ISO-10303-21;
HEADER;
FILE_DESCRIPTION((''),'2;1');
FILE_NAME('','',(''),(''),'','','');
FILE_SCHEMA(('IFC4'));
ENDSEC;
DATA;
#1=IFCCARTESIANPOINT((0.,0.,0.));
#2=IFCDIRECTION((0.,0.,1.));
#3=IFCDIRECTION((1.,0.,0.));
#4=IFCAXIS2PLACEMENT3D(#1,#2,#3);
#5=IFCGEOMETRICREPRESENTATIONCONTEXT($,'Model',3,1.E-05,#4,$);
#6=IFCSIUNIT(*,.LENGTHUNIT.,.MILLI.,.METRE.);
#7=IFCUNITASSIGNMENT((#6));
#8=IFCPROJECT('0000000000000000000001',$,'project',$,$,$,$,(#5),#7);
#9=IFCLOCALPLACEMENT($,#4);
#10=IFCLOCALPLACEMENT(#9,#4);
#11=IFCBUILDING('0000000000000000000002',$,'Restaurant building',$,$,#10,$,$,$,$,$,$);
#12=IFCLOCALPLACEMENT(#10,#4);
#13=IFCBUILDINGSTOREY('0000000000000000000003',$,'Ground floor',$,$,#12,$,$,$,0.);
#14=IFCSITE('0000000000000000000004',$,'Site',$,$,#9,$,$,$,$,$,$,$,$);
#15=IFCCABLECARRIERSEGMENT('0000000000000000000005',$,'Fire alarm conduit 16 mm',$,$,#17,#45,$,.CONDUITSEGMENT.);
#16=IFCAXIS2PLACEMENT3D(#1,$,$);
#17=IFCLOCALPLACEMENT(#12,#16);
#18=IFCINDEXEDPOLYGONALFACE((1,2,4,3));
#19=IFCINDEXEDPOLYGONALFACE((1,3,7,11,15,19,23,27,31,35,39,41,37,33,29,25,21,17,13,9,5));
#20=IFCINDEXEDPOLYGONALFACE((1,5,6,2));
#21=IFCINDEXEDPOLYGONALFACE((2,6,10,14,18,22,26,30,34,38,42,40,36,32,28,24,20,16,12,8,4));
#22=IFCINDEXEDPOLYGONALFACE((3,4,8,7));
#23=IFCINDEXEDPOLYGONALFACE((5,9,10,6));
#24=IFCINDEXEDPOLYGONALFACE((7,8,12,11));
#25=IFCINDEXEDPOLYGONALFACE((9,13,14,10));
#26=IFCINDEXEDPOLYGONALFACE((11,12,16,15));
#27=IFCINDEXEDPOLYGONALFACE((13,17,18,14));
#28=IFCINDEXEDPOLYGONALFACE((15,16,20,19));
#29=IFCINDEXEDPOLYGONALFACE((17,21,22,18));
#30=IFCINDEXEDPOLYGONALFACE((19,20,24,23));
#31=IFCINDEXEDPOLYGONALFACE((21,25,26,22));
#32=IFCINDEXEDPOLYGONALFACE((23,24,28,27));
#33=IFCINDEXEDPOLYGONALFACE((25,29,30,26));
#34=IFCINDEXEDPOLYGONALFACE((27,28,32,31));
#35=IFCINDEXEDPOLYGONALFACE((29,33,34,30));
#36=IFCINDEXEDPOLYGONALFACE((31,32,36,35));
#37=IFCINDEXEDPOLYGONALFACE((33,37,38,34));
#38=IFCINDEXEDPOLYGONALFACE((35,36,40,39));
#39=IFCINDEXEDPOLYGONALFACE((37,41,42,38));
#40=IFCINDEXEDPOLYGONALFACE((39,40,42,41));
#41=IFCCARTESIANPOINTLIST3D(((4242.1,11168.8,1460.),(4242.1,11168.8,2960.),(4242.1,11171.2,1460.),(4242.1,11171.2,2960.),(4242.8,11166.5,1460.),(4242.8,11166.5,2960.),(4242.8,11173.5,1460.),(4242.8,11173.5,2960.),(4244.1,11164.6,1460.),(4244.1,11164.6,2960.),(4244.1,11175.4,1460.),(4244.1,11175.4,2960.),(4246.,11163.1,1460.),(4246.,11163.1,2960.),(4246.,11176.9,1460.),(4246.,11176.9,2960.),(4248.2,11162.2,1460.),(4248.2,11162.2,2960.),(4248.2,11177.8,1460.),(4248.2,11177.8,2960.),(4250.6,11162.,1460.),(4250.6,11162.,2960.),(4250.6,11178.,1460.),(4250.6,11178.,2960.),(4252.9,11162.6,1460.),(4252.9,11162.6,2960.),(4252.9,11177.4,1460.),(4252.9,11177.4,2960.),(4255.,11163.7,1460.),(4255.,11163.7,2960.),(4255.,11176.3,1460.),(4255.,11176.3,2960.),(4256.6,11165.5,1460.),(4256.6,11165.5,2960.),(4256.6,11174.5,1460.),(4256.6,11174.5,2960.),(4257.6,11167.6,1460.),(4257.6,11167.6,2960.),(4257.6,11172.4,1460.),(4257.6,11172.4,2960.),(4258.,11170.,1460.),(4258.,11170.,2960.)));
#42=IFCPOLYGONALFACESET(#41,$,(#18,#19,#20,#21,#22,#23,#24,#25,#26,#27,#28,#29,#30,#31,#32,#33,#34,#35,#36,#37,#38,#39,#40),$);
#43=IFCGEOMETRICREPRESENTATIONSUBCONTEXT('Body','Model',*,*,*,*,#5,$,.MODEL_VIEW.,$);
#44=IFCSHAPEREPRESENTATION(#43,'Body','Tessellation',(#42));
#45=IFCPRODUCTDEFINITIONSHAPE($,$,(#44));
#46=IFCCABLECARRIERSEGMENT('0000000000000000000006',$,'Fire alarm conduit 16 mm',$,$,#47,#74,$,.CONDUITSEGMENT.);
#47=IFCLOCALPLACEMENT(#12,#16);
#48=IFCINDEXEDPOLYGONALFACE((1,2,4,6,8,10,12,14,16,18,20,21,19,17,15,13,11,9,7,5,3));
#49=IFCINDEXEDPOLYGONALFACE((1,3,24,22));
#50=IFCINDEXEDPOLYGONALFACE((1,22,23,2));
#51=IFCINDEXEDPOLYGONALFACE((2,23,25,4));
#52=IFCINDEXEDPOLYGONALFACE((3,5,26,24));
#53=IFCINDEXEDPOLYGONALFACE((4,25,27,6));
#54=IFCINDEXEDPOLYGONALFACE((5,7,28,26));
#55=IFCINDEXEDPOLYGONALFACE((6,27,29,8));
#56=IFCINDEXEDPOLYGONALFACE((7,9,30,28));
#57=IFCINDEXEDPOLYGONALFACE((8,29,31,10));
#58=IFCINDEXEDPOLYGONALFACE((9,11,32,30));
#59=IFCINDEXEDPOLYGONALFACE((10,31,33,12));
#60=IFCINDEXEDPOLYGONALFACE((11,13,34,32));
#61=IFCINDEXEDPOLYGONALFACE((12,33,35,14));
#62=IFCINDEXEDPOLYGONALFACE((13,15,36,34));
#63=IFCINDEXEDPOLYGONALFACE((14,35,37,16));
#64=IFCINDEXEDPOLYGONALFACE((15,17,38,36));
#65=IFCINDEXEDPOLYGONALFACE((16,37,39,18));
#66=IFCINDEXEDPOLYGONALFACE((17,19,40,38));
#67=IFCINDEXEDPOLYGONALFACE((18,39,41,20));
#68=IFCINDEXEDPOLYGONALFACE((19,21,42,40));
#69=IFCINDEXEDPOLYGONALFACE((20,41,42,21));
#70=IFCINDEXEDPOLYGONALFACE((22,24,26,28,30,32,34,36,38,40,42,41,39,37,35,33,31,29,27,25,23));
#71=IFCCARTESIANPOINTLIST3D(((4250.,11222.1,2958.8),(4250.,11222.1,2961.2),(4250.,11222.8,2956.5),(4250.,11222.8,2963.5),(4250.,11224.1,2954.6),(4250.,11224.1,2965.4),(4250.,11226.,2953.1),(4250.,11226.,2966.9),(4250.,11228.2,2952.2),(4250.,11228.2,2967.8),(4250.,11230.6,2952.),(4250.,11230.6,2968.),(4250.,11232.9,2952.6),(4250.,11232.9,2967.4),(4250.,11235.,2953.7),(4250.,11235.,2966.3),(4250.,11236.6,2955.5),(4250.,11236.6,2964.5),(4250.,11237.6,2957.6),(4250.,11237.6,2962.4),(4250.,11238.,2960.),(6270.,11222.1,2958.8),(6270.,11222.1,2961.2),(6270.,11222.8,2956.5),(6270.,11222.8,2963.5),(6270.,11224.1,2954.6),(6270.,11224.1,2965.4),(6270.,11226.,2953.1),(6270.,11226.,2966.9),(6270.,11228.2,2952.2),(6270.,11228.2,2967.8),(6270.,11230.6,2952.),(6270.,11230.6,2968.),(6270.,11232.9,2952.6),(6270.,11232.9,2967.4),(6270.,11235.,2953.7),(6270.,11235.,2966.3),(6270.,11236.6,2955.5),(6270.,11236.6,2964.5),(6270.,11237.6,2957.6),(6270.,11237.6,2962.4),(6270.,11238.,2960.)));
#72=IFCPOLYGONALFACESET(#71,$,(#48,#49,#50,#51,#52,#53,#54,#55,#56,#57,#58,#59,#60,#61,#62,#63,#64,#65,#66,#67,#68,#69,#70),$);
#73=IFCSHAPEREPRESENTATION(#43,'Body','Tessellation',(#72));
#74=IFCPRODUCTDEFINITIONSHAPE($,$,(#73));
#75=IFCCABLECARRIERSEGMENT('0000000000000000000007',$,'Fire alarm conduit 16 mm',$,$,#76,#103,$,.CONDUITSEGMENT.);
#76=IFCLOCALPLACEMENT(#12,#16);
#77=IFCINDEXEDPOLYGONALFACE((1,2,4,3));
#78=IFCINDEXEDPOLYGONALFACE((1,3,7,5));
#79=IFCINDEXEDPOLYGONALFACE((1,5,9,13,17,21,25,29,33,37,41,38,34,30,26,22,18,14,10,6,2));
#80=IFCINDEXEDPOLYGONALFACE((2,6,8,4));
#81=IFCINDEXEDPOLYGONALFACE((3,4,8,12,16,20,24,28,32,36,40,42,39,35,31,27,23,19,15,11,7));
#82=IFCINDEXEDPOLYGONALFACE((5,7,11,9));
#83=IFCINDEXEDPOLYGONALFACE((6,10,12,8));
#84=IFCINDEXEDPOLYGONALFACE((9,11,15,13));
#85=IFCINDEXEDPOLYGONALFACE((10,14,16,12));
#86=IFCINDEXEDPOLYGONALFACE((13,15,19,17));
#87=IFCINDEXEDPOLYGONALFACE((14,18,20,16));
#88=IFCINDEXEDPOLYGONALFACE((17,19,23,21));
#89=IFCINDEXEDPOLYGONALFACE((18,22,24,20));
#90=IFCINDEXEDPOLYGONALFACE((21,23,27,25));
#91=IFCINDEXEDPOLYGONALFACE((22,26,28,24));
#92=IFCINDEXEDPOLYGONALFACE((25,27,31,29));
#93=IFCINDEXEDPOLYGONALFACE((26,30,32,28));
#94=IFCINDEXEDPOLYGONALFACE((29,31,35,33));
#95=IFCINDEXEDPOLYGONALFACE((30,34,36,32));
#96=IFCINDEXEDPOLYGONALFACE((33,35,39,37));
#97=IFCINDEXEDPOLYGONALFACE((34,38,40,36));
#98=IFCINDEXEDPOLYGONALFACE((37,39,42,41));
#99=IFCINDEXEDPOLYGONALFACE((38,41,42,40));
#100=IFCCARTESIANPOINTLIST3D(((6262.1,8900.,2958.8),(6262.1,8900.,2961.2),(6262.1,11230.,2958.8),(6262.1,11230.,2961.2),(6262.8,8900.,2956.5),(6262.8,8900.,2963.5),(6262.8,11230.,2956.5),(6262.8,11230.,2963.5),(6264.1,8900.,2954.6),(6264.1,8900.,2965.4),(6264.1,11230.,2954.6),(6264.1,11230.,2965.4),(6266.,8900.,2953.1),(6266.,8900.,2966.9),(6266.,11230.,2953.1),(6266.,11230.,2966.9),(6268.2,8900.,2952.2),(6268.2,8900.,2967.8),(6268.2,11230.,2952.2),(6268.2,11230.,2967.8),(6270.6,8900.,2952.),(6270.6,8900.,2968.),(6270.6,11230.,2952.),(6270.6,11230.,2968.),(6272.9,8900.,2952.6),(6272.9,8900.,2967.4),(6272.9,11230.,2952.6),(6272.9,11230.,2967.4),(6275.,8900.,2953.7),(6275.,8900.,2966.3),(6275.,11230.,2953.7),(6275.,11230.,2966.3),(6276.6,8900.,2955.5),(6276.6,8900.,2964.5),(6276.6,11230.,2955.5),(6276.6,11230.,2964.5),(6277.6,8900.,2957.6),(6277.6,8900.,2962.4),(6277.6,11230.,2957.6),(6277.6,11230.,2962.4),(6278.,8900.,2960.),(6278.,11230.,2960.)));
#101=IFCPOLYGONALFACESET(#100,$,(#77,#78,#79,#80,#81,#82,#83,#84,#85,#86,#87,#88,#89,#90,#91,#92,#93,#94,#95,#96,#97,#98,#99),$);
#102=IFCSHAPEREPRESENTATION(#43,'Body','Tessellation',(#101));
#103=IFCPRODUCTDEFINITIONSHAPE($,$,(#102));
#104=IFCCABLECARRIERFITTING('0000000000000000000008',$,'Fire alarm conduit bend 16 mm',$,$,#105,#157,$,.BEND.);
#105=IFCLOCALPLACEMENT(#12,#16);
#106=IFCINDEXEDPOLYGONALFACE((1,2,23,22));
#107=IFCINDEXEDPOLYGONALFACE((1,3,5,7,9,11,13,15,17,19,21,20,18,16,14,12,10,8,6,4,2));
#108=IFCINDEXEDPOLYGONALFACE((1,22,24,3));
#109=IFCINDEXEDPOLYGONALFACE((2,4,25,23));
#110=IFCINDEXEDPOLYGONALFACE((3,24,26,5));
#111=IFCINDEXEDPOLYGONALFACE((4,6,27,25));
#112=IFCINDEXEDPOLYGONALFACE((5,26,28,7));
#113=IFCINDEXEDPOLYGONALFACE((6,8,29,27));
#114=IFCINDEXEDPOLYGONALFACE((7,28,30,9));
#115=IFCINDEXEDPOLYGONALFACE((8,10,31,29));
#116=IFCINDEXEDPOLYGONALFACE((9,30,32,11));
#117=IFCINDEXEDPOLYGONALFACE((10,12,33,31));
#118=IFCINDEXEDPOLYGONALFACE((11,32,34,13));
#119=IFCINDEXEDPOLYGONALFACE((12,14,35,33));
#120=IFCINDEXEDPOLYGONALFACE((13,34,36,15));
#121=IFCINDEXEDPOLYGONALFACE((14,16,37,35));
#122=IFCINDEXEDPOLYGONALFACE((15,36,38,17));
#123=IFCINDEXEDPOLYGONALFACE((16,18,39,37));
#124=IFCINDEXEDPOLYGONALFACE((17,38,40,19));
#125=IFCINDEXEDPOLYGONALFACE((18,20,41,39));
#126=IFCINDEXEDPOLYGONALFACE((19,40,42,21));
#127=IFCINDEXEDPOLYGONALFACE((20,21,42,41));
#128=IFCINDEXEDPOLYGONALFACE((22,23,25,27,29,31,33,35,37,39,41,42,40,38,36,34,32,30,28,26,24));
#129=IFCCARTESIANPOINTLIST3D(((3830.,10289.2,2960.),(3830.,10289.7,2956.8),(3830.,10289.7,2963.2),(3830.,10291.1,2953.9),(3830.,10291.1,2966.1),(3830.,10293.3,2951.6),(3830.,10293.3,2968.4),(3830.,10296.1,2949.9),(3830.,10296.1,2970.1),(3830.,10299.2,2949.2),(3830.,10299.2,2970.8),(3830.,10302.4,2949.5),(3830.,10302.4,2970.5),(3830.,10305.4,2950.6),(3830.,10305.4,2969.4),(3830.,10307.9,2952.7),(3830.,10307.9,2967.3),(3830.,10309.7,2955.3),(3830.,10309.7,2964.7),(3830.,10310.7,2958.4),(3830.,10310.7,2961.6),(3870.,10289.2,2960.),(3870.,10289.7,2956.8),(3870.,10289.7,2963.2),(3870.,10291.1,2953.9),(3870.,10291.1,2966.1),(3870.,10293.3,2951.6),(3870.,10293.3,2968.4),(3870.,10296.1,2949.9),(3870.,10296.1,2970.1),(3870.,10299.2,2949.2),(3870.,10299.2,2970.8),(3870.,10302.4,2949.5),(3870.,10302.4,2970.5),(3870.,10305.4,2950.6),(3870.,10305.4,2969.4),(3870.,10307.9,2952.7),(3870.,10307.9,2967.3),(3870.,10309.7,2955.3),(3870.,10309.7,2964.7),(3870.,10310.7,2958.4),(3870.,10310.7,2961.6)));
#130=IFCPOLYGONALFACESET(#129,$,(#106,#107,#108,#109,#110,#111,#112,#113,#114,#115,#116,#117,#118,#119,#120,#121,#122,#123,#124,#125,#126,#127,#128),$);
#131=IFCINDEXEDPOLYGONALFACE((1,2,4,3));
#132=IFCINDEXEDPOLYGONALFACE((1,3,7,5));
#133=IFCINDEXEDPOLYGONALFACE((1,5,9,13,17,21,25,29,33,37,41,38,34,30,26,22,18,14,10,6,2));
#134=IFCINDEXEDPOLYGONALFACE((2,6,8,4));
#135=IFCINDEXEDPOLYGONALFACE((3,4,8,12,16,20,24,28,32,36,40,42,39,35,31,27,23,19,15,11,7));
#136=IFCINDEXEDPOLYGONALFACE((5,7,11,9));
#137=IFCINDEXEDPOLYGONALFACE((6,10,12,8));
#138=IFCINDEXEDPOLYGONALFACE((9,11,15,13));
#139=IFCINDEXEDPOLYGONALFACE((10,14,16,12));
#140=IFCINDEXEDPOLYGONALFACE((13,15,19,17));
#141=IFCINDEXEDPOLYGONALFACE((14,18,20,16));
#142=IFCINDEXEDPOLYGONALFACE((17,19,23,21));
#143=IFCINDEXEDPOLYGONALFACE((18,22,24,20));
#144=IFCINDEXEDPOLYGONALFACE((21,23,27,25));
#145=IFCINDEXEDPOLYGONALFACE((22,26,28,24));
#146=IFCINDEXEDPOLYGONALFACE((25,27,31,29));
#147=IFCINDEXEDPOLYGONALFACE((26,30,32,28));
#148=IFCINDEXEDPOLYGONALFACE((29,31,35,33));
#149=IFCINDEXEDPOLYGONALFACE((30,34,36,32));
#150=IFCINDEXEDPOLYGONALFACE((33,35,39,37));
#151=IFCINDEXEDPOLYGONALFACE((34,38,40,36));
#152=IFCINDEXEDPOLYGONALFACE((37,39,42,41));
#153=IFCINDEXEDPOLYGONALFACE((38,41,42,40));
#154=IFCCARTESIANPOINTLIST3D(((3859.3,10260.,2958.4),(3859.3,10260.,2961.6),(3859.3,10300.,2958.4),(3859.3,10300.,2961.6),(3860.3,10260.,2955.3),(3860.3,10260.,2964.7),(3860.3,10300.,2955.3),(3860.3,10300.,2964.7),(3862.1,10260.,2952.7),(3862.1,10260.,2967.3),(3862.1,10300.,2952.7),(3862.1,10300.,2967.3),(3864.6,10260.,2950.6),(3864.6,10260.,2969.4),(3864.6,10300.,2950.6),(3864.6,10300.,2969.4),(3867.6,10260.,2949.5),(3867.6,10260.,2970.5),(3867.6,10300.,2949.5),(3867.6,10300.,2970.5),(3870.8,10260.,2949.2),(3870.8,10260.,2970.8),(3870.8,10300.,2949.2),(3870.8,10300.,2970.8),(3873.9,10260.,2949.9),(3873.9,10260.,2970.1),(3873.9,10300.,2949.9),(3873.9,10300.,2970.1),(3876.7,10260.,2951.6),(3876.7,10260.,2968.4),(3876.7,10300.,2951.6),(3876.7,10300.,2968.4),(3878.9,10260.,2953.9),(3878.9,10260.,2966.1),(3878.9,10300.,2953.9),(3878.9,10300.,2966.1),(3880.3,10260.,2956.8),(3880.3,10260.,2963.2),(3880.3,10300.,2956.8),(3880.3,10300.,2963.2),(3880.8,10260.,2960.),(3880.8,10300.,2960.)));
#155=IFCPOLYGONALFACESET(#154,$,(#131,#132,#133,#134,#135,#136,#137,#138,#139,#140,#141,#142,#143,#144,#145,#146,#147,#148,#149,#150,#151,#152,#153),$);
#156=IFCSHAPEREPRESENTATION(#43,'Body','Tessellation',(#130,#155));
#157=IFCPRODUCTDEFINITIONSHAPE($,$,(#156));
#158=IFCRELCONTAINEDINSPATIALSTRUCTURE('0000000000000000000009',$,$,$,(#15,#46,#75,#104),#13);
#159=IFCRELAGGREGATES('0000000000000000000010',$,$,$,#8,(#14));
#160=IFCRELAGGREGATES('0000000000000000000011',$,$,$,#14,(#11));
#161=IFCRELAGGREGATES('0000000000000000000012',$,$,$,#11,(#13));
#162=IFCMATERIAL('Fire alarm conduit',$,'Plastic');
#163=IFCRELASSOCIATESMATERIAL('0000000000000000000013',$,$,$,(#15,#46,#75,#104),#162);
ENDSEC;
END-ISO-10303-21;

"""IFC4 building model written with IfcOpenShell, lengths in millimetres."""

from ifc_helpers import new_model, si_unit, frame, origin_with_axes, origin_2d, place, context, subcontext, project, spatial, circle, extrude, material, element, save


model = new_model("IFC4")

# Units and contexts
model_context = context("Model", 3, precision=1e-05, world=origin_with_axes())
body_context = subcontext(model_context, "Body", "Model", "MODEL_VIEW")
ifc_project = project(units=[si_unit("LENGTHUNIT", "METRE", prefix="MILLI")], contexts=[model_context])

# Site, building, storey
site_placement = place(None, origin_with_axes())
site = spatial("IfcSite", under=ifc_project, at=site_placement, Name="Site")
building_placement = place(site_placement, origin_with_axes())
building = spatial("IfcBuilding", under=site, at=building_placement, Name="Restaurant building")
storey_placement = place(building_placement, origin_with_axes())
storey = spatial("IfcBuildingStorey", under=building, at=storey_placement, Name="Ground floor", Elevation=0.0)

# Cable carrier segments
ifc_material_1 = material(Name="Fire alarm conduit", Category="Plastic")
cable_carrier_segment_1_placement = place(storey_placement, frame((4250.0, 11170.0, 2960.0)))
element("IfcCableCarrierSegment", 1, at=cable_carrier_segment_1_placement, inside=storey, material=ifc_material_1, Name="Fire alarm conduit 16 mm", PredefinedType="CONDUITSEGMENT", context=body_context, shape_type="SweptSolid", body=[
    extrude(circle(Radius=8.0, at=origin_2d()), frame((0.0, 0.0, 0.0), z_axis=(0.0, 0.0, -1.0), x_axis=(1.0, 0.0, 0.0)), (0.0, 0.0, 1.0), 1500.0),
])
cable_carrier_segment_2_placement = place(storey_placement, frame((4250.0, 11230.0, 2960.0)))
element("IfcCableCarrierSegment", 2, at=cable_carrier_segment_2_placement, inside=storey, material=ifc_material_1, Name="Fire alarm conduit 16 mm", PredefinedType="CONDUITSEGMENT", context=body_context, shape_type="SweptSolid", body=[
    extrude(circle(Radius=8.0, at=origin_2d()), frame((0.0, 0.0, 0.0), z_axis=(1.0, 0.0, 0.0), x_axis=(0.0, 1.0, 0.0)), (0.0, 0.0, 1.0), 2020.0),
])
cable_carrier_segment_3_placement = place(storey_placement, frame((6270.0, 11230.0, 2960.0)))
element("IfcCableCarrierSegment", 3, at=cable_carrier_segment_3_placement, inside=storey, material=ifc_material_1, Name="Fire alarm conduit 16 mm", PredefinedType="CONDUITSEGMENT", context=body_context, shape_type="SweptSolid", body=[
    extrude(circle(Radius=8.0, at=origin_2d()), frame((0.0, 0.0, 0.0), z_axis=(0.0, -1.0, 0.0), x_axis=(1.0, 0.0, 0.0)), (0.0, 0.0, 1.0), 2330.0),
])

# Cable carrier fitting
cable_carrier_fitting_1_placement = place(storey_placement, frame((3870.0, 10300.0, 2960.0)))
element("IfcCableCarrierFitting", 4, at=cable_carrier_fitting_1_placement, inside=storey, material=ifc_material_1, Name="Fire alarm conduit bend 16 mm", PredefinedType="BEND", context=body_context, shape_type="SweptSolid", body=[
    extrude(circle(Radius=10.8, at=origin_2d()), frame((0.0, 0.0, 0.0), z_axis=(-1.0, 0.0, 0.0), x_axis=(0.0, -1.0, 0.0)), (0.0, 0.0, 1.0), 40.0),
    extrude(circle(Radius=10.8, at=origin_2d()), frame((0.0, 0.0, 0.0), z_axis=(0.0, -1.0, 0.0), x_axis=(1.0, 0.0, 0.0)), (0.0, 0.0, 1.0), 40.0),
])

save(model, "model.ifc")
